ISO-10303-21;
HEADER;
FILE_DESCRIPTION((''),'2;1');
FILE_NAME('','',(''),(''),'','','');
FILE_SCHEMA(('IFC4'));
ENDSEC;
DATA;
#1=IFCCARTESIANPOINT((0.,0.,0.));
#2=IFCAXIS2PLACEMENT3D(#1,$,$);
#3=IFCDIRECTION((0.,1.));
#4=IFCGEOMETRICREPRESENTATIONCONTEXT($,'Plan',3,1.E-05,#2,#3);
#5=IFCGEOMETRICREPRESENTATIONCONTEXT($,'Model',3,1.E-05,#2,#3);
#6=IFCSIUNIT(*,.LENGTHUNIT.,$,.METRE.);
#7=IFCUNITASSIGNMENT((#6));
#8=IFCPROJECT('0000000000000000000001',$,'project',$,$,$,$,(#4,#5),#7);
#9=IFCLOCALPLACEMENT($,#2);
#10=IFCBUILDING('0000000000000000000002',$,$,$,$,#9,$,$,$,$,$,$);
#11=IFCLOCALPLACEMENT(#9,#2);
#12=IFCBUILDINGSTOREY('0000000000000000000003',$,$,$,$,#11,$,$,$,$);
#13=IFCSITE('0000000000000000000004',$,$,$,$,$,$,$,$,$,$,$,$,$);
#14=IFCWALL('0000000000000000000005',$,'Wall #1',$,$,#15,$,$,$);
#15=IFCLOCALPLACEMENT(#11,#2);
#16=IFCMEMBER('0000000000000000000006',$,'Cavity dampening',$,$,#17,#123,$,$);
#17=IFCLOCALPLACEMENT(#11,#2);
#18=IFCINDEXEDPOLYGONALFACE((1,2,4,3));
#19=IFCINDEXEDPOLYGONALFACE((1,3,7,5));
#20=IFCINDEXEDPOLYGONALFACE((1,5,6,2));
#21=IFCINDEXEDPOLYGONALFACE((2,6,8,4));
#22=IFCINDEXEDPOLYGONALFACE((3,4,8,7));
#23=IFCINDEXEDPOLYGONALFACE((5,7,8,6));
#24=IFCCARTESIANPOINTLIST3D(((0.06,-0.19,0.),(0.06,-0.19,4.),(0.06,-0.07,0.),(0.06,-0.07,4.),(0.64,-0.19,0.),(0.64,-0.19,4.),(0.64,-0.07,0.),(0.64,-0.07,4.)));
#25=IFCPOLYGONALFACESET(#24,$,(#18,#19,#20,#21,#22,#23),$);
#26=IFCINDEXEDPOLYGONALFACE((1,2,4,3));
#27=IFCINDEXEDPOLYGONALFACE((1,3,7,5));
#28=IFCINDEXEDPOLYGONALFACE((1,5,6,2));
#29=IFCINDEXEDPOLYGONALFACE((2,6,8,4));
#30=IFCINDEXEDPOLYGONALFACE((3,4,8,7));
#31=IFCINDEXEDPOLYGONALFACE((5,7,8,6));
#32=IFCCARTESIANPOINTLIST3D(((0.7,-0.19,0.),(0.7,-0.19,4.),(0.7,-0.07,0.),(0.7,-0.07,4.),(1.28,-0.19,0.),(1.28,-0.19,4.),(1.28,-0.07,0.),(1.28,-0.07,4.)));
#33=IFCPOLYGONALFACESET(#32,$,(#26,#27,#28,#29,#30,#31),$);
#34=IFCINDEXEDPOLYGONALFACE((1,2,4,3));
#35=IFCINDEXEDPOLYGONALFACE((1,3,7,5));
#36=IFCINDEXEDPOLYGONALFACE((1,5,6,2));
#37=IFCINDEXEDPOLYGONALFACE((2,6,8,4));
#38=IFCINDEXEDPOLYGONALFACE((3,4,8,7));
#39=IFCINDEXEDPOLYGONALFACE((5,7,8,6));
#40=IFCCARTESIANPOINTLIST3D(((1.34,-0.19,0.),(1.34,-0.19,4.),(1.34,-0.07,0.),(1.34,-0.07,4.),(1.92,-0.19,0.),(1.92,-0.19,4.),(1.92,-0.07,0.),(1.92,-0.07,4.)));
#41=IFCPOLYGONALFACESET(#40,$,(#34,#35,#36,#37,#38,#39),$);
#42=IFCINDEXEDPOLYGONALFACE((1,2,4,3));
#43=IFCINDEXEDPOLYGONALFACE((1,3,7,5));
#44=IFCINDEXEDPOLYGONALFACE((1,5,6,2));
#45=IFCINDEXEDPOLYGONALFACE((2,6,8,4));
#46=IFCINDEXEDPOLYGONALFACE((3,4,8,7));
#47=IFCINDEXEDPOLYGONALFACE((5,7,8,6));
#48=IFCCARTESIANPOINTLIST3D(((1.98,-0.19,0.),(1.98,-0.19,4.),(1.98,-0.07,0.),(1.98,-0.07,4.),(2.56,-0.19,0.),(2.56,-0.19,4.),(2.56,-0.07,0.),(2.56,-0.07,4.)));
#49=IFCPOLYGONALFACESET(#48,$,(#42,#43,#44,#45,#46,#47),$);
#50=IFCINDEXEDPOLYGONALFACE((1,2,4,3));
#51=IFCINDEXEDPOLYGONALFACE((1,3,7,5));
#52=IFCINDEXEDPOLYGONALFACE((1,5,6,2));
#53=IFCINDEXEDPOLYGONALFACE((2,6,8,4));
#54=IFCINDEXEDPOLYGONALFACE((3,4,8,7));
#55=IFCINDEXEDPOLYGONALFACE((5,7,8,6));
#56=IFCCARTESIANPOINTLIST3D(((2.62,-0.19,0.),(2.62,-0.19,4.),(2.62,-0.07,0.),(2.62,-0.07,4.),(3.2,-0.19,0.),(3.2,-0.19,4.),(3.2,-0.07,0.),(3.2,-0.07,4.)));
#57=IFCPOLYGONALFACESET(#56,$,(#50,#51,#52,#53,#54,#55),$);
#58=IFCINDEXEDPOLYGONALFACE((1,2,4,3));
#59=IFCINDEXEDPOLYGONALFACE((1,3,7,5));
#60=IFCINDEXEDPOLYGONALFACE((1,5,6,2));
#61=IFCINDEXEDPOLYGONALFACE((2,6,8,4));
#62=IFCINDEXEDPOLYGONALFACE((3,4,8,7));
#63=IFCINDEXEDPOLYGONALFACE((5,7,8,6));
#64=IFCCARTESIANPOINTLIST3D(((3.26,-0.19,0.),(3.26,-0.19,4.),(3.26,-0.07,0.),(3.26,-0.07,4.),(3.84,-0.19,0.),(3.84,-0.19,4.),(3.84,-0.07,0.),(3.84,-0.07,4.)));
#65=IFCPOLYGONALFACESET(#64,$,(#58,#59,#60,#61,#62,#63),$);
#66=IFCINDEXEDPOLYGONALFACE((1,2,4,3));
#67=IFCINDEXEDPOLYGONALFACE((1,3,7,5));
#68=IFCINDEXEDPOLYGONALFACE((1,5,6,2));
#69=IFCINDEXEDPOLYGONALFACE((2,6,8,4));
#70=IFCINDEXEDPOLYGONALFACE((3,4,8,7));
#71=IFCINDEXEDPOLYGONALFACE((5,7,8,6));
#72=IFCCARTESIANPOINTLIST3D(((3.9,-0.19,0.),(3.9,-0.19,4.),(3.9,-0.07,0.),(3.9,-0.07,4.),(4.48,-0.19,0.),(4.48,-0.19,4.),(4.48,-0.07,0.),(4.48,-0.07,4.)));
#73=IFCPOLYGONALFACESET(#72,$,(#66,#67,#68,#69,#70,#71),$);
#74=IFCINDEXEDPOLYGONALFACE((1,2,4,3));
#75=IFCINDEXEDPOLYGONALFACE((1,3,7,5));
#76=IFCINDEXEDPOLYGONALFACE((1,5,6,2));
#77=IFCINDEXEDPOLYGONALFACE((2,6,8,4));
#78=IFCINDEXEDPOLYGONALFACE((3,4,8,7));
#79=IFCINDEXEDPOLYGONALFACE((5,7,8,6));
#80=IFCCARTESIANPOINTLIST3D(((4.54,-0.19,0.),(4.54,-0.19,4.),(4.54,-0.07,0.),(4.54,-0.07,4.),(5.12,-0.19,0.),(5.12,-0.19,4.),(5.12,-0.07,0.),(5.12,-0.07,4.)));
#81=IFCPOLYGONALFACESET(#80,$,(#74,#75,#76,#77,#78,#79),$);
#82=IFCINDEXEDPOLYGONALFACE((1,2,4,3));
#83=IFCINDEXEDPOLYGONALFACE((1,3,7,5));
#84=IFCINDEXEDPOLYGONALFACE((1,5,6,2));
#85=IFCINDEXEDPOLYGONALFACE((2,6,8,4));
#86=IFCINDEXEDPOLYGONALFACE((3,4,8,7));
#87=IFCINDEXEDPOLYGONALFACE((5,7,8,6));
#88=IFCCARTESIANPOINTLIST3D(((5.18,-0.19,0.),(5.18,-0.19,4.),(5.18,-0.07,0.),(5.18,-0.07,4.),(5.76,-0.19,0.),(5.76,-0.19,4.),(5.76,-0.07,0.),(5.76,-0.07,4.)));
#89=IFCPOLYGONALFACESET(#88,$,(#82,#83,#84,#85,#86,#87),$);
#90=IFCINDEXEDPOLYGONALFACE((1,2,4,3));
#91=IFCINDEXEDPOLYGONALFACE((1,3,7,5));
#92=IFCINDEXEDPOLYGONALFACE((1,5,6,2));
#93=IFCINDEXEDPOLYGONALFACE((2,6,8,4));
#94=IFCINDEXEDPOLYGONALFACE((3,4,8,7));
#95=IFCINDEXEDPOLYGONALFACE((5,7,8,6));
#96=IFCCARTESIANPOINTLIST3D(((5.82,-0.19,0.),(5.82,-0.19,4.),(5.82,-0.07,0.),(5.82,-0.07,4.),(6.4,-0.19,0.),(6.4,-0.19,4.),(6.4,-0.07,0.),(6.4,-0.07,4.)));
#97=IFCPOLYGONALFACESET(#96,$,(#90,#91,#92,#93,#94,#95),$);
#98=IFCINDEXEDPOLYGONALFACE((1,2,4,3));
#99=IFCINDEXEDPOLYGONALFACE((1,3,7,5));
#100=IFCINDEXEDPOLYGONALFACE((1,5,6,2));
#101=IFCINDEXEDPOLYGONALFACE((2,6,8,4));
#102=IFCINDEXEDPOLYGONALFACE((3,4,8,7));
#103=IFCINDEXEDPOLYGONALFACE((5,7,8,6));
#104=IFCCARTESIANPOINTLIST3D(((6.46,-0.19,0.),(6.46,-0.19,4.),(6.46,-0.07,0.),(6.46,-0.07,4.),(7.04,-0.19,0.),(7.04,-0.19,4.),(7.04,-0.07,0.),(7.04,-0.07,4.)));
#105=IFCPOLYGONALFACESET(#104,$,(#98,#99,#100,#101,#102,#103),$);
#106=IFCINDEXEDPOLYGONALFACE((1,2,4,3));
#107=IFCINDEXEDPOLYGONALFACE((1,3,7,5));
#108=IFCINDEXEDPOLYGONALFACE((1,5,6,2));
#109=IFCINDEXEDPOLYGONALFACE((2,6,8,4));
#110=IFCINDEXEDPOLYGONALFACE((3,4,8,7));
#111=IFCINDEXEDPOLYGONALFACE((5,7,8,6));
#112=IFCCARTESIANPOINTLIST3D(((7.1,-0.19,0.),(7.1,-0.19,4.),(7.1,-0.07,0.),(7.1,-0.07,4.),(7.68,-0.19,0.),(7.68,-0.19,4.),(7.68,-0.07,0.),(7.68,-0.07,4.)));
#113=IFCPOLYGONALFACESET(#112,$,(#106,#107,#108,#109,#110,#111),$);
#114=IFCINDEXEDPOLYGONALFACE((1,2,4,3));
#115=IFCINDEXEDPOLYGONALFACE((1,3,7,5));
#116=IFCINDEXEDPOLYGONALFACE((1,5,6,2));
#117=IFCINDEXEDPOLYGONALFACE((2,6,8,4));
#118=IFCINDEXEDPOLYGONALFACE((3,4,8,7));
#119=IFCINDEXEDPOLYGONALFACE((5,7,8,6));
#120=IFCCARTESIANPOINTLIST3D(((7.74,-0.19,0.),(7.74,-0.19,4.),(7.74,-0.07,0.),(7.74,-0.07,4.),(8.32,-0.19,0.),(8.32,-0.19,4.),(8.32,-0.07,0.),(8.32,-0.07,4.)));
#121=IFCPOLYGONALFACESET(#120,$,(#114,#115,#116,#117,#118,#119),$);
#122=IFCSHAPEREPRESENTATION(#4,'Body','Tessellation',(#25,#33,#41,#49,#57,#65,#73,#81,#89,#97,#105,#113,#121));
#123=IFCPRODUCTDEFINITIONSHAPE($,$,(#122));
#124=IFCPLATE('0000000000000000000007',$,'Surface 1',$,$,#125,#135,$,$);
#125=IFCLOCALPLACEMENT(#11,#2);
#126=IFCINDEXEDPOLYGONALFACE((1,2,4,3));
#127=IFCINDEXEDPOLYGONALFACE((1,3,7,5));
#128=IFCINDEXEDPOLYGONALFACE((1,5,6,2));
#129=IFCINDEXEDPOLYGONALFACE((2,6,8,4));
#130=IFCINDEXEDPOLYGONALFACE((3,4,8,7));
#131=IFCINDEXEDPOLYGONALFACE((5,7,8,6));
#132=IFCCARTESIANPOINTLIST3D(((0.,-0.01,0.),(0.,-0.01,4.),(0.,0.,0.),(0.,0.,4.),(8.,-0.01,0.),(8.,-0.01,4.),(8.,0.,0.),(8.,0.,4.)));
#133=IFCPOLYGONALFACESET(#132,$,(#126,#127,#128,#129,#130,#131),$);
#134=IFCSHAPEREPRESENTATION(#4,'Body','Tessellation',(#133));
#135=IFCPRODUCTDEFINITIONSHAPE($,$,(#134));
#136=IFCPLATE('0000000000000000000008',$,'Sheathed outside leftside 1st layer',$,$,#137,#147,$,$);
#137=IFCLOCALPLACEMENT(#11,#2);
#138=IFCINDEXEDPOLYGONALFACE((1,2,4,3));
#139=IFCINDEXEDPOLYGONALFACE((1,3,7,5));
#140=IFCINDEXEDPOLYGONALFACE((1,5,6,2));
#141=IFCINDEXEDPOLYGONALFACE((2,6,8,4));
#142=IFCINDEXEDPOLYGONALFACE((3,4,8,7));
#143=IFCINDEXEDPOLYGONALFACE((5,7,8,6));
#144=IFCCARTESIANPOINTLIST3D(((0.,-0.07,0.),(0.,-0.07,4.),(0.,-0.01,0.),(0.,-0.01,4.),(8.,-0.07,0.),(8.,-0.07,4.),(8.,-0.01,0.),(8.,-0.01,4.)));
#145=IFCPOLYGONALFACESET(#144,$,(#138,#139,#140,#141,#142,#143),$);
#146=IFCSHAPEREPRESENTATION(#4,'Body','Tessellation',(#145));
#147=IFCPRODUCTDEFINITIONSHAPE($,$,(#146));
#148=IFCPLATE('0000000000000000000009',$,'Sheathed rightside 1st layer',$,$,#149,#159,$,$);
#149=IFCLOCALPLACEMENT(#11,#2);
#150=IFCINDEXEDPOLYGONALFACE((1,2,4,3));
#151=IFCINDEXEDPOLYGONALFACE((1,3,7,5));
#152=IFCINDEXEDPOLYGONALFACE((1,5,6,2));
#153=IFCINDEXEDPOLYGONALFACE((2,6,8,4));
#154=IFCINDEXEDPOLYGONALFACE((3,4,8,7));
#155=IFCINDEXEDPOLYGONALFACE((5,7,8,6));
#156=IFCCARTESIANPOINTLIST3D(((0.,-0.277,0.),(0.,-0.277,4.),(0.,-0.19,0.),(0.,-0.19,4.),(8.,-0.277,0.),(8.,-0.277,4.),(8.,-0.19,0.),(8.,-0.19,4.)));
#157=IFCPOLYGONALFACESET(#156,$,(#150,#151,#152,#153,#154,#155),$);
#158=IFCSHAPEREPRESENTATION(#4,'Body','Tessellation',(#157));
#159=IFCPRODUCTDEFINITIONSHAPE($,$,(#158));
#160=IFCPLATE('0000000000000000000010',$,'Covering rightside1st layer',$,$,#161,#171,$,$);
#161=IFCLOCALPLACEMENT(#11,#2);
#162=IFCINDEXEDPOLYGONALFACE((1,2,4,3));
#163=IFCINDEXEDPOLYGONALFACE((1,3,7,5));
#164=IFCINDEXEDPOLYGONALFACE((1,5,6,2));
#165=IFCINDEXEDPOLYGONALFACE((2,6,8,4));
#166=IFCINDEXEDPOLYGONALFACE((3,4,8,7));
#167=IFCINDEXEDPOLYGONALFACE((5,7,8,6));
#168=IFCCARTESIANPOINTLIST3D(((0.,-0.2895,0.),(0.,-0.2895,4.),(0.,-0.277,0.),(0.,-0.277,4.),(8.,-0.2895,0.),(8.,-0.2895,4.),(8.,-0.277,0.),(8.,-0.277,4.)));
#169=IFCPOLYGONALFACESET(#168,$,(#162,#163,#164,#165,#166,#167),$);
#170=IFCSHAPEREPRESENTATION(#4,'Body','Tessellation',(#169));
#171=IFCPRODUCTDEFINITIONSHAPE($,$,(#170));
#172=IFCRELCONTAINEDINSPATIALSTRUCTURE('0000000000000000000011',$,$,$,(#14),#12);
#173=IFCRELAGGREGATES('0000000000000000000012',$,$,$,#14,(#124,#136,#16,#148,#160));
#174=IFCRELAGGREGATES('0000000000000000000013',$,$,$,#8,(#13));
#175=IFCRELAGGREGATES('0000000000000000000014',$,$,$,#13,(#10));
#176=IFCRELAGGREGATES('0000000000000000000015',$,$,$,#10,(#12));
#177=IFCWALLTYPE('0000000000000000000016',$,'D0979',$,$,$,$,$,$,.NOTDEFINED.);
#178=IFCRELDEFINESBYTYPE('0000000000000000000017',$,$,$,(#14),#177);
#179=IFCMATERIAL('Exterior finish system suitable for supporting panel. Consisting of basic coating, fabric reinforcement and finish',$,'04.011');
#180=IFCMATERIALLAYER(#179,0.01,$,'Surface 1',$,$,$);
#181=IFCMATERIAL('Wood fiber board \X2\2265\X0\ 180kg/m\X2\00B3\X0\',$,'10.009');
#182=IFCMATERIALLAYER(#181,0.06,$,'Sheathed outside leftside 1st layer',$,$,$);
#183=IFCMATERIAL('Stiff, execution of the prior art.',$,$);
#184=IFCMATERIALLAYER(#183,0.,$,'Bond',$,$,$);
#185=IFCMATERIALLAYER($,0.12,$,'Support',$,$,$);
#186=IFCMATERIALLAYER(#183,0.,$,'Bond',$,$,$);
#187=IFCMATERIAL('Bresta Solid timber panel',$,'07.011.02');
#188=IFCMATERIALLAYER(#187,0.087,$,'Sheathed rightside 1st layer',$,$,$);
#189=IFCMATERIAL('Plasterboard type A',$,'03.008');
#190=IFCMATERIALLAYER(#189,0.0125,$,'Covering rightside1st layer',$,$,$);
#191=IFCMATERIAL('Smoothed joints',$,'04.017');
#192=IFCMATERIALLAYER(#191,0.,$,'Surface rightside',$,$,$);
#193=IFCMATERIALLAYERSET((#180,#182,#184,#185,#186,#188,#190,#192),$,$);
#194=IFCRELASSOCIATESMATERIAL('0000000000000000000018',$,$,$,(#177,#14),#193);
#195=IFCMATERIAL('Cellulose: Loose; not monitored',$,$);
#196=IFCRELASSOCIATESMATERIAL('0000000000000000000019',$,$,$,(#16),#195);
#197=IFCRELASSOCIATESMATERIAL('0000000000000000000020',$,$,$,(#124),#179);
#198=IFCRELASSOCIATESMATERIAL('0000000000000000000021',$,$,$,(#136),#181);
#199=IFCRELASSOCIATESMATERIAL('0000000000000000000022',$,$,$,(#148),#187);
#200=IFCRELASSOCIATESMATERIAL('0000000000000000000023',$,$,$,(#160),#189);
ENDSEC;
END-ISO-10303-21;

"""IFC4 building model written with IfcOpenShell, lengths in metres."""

from ifc_helpers import new_model, si_unit, direction, frame, frame_2d, origin, origin_with_axes, place, context, project, spatial, rectangle, extrude, material, layer, layer_set, type_object, element, aggregate, save


model = new_model("IFC4")

# Units and contexts
plan_context = context("Plan", 3, precision=1e-05, world=origin(), true_north=direction((0.0, 1.0)))
model_context = context("Model", 3, precision=1e-05, world=origin(), true_north=direction((0.0, 1.0)))
ifc_project = project(units=[si_unit("LENGTHUNIT", "METRE")], contexts=[plan_context, model_context])

# Site, building, storey
site = spatial("IfcSite", under=ifc_project)
building_placement = place(None, origin())
building = spatial("IfcBuilding", under=site, at=building_placement)
storey_placement = place(building_placement, origin())
storey = spatial("IfcBuildingStorey", under=building, at=storey_placement)

# Wall, member, plates
ifc_material_1 = material(Name="Exterior finish system suitable for supporting panel. Consisting of basic coating, fabric reinforcement and finish", Category="04.011")
ifc_layer_1 = layer(ifc_material_1, 0.01, Name="Surface 1")
ifc_material_2 = material(Name="Wood fiber board ≥ 180kg/m³", Category="10.009")
ifc_layer_2 = layer(ifc_material_2, 0.06, Name="Sheathed outside leftside 1st layer")
ifc_material_3 = material(Name="Stiff, execution of the prior art.")
ifc_layer_3 = layer(ifc_material_3, 0.0, Name="Bond")
ifc_layer_4 = layer(None, 0.12, Name="Support")
ifc_layer_5 = layer(ifc_material_3, 0.0, Name="Bond")
ifc_material_4 = material(Name="Bresta Solid timber panel", Category="07.011.02")
ifc_layer_6 = layer(ifc_material_4, 0.087, Name="Sheathed rightside 1st layer")
ifc_material_5 = material(Name="Plasterboard type A", Category="03.008")
ifc_layer_7 = layer(ifc_material_5, 0.0125, Name="Covering rightside1st layer")
ifc_material_6 = material(Name="Smoothed joints", Category="04.017")
ifc_layer_8 = layer(ifc_material_6, 0.0, Name="Surface rightside")
ifc_layer_set = layer_set([ifc_layer_1, ifc_layer_2, ifc_layer_3, ifc_layer_4, ifc_layer_5, ifc_layer_6, ifc_layer_7, ifc_layer_8])
wall_type = type_object("IfcWallType", Name="D0979", PredefinedType="NOTDEFINED", material=ifc_layer_set)
wall_placement = place(None, frame((0.0, 0.0, 0.0), z_axis=(0.0, -1.0, 0.0), x_axis=(1.0, 0.0, 0.0)))
wall = element("IfcWall", 1, at=wall_placement, inside=storey, type_object=wall_type, material=ifc_layer_set, Name="Wall #1")
ifc_material_7 = material(Name="Cellulose: Loose; not monitored")
member_1_placement = place(wall_placement, origin())
member_1 = element("IfcMember", 2, at=member_1_placement, material=ifc_material_7, Name="Cavity dampening", context=plan_context, shape_type="SweptSolid", body=[
    extrude(rectangle(XDim=0.58, YDim=0.12, at=frame_2d((0.29, 0.06), x_axis=(1.0, 0.0))), frame((0.06, 4.0, 0.07), z_axis=(0.0, -1.0, 0.0), x_axis=(1.0, 0.0, 0.0)), (0.0, 0.0, 1.0), 4.0),
    extrude(rectangle(XDim=0.58, YDim=0.12, at=frame_2d((0.29, 0.06), x_axis=(1.0, 0.0))), frame((0.7, 4.0, 0.07), z_axis=(0.0, -1.0, 0.0), x_axis=(1.0, 0.0, 0.0)), (0.0, 0.0, 1.0), 4.0),
    extrude(rectangle(XDim=0.58, YDim=0.12, at=frame_2d((0.29, 0.06), x_axis=(1.0, 0.0))), frame((1.34, 4.0, 0.07), z_axis=(0.0, -1.0, 0.0), x_axis=(1.0, 0.0, 0.0)), (0.0, 0.0, 1.0), 4.0),
    extrude(rectangle(XDim=0.58, YDim=0.12, at=frame_2d((0.29, 0.06), x_axis=(1.0, 0.0))), frame((1.98, 4.0, 0.07), z_axis=(0.0, -1.0, 0.0), x_axis=(1.0, 0.0, 0.0)), (0.0, 0.0, 1.0), 4.0),
    extrude(rectangle(XDim=0.58, YDim=0.12, at=frame_2d((0.29, 0.06), x_axis=(1.0, 0.0))), frame((2.62, 4.0, 0.07), z_axis=(0.0, -1.0, 0.0), x_axis=(1.0, 0.0, 0.0)), (0.0, 0.0, 1.0), 4.0),
    extrude(rectangle(XDim=0.58, YDim=0.12, at=frame_2d((0.29, 0.06), x_axis=(1.0, 0.0))), frame((3.26, 4.0, 0.07), z_axis=(0.0, -1.0, 0.0), x_axis=(1.0, 0.0, 0.0)), (0.0, 0.0, 1.0), 4.0),
    extrude(rectangle(XDim=0.58, YDim=0.12, at=frame_2d((0.29, 0.06), x_axis=(1.0, 0.0))), frame((3.9, 4.0, 0.07), z_axis=(0.0, -1.0, 0.0), x_axis=(1.0, 0.0, 0.0)), (0.0, 0.0, 1.0), 4.0),
    extrude(rectangle(XDim=0.58, YDim=0.12, at=frame_2d((0.29, 0.06), x_axis=(1.0, 0.0))), frame((4.54, 4.0, 0.07), z_axis=(0.0, -1.0, 0.0), x_axis=(1.0, 0.0, 0.0)), (0.0, 0.0, 1.0), 4.0),
    extrude(rectangle(XDim=0.58, YDim=0.12, at=frame_2d((0.29, 0.06), x_axis=(1.0, 0.0))), frame((5.18, 4.0, 0.07), z_axis=(0.0, -1.0, 0.0), x_axis=(1.0, 0.0, 0.0)), (0.0, 0.0, 1.0), 4.0),
    extrude(rectangle(XDim=0.58, YDim=0.12, at=frame_2d((0.29, 0.06), x_axis=(1.0, 0.0))), frame((5.82, 4.0, 0.07), z_axis=(0.0, -1.0, 0.0), x_axis=(1.0, 0.0, 0.0)), (0.0, 0.0, 1.0), 4.0),
    extrude(rectangle(XDim=0.58, YDim=0.12, at=frame_2d((0.29, 0.06), x_axis=(1.0, 0.0))), frame((6.46, 4.0, 0.07), z_axis=(0.0, -1.0, 0.0), x_axis=(1.0, 0.0, 0.0)), (0.0, 0.0, 1.0), 4.0),
    extrude(rectangle(XDim=0.58, YDim=0.12, at=frame_2d((0.29, 0.06), x_axis=(1.0, 0.0))), frame((7.1, 4.0, 0.07), z_axis=(0.0, -1.0, 0.0), x_axis=(1.0, 0.0, 0.0)), (0.0, 0.0, 1.0), 4.0),
    extrude(rectangle(XDim=0.58, YDim=0.12, at=frame_2d((0.29, 0.06), x_axis=(1.0, 0.0))), frame((7.74, 4.0, 0.07), z_axis=(0.0, -1.0, 0.0), x_axis=(1.0, 0.0, 0.0)), (0.0, 0.0, 1.0), 4.0),
])
plate_1_placement = place(wall_placement, origin())
plate_1 = element("IfcPlate", 3, at=plate_1_placement, material=ifc_material_1, Name="Surface 1", context=plan_context, shape_type="SweptSolid", body=[
    extrude(rectangle(XDim=8.0, YDim=4.0, at=frame_2d((4.0, 2.0), x_axis=(1.0, 0.0))), origin_with_axes(), (0.0, 0.0, 1.0), 0.01),
])
plate_2_placement = place(wall_placement, origin())
plate_2 = element("IfcPlate", 4, at=plate_2_placement, material=ifc_material_2, Name="Sheathed outside leftside 1st layer", context=plan_context, shape_type="SweptSolid", body=[
    extrude(rectangle(XDim=8.0, YDim=4.0, at=frame_2d((4.0, 2.0), x_axis=(1.0, 0.0))), frame((0.0, 0.0, 0.01), z_axis=(0.0, 0.0, 1.0), x_axis=(1.0, 0.0, 0.0)), (0.0, 0.0, 1.0), 0.06),
])
plate_3_placement = place(wall_placement, origin())
plate_3 = element("IfcPlate", 5, at=plate_3_placement, material=ifc_material_4, Name="Sheathed rightside 1st layer", context=plan_context, shape_type="SweptSolid", body=[
    extrude(rectangle(XDim=8.0, YDim=4.0, at=frame_2d((4.0, 2.0), x_axis=(1.0, 0.0))), frame((0.0, 0.0, 0.19), z_axis=(0.0, 0.0, 1.0), x_axis=(1.0, 0.0, 0.0)), (0.0, 0.0, 1.0), 0.087),
])
plate_4_placement = place(wall_placement, origin())
plate_4 = element("IfcPlate", 6, at=plate_4_placement, material=ifc_material_5, Name="Covering rightside1st layer", context=plan_context, shape_type="SweptSolid", body=[
    extrude(rectangle(XDim=8.0, YDim=4.0, at=frame_2d((4.0, 2.0), x_axis=(1.0, 0.0))), frame((0.0, 0.0, 0.277), z_axis=(0.0, 0.0, 1.0), x_axis=(1.0, 0.0, 0.0)), (0.0, 0.0, 1.0), 0.0125),
])
aggregate(wall, [plate_1, plate_2, member_1, plate_3, plate_4])

save(model, "model.ifc")
